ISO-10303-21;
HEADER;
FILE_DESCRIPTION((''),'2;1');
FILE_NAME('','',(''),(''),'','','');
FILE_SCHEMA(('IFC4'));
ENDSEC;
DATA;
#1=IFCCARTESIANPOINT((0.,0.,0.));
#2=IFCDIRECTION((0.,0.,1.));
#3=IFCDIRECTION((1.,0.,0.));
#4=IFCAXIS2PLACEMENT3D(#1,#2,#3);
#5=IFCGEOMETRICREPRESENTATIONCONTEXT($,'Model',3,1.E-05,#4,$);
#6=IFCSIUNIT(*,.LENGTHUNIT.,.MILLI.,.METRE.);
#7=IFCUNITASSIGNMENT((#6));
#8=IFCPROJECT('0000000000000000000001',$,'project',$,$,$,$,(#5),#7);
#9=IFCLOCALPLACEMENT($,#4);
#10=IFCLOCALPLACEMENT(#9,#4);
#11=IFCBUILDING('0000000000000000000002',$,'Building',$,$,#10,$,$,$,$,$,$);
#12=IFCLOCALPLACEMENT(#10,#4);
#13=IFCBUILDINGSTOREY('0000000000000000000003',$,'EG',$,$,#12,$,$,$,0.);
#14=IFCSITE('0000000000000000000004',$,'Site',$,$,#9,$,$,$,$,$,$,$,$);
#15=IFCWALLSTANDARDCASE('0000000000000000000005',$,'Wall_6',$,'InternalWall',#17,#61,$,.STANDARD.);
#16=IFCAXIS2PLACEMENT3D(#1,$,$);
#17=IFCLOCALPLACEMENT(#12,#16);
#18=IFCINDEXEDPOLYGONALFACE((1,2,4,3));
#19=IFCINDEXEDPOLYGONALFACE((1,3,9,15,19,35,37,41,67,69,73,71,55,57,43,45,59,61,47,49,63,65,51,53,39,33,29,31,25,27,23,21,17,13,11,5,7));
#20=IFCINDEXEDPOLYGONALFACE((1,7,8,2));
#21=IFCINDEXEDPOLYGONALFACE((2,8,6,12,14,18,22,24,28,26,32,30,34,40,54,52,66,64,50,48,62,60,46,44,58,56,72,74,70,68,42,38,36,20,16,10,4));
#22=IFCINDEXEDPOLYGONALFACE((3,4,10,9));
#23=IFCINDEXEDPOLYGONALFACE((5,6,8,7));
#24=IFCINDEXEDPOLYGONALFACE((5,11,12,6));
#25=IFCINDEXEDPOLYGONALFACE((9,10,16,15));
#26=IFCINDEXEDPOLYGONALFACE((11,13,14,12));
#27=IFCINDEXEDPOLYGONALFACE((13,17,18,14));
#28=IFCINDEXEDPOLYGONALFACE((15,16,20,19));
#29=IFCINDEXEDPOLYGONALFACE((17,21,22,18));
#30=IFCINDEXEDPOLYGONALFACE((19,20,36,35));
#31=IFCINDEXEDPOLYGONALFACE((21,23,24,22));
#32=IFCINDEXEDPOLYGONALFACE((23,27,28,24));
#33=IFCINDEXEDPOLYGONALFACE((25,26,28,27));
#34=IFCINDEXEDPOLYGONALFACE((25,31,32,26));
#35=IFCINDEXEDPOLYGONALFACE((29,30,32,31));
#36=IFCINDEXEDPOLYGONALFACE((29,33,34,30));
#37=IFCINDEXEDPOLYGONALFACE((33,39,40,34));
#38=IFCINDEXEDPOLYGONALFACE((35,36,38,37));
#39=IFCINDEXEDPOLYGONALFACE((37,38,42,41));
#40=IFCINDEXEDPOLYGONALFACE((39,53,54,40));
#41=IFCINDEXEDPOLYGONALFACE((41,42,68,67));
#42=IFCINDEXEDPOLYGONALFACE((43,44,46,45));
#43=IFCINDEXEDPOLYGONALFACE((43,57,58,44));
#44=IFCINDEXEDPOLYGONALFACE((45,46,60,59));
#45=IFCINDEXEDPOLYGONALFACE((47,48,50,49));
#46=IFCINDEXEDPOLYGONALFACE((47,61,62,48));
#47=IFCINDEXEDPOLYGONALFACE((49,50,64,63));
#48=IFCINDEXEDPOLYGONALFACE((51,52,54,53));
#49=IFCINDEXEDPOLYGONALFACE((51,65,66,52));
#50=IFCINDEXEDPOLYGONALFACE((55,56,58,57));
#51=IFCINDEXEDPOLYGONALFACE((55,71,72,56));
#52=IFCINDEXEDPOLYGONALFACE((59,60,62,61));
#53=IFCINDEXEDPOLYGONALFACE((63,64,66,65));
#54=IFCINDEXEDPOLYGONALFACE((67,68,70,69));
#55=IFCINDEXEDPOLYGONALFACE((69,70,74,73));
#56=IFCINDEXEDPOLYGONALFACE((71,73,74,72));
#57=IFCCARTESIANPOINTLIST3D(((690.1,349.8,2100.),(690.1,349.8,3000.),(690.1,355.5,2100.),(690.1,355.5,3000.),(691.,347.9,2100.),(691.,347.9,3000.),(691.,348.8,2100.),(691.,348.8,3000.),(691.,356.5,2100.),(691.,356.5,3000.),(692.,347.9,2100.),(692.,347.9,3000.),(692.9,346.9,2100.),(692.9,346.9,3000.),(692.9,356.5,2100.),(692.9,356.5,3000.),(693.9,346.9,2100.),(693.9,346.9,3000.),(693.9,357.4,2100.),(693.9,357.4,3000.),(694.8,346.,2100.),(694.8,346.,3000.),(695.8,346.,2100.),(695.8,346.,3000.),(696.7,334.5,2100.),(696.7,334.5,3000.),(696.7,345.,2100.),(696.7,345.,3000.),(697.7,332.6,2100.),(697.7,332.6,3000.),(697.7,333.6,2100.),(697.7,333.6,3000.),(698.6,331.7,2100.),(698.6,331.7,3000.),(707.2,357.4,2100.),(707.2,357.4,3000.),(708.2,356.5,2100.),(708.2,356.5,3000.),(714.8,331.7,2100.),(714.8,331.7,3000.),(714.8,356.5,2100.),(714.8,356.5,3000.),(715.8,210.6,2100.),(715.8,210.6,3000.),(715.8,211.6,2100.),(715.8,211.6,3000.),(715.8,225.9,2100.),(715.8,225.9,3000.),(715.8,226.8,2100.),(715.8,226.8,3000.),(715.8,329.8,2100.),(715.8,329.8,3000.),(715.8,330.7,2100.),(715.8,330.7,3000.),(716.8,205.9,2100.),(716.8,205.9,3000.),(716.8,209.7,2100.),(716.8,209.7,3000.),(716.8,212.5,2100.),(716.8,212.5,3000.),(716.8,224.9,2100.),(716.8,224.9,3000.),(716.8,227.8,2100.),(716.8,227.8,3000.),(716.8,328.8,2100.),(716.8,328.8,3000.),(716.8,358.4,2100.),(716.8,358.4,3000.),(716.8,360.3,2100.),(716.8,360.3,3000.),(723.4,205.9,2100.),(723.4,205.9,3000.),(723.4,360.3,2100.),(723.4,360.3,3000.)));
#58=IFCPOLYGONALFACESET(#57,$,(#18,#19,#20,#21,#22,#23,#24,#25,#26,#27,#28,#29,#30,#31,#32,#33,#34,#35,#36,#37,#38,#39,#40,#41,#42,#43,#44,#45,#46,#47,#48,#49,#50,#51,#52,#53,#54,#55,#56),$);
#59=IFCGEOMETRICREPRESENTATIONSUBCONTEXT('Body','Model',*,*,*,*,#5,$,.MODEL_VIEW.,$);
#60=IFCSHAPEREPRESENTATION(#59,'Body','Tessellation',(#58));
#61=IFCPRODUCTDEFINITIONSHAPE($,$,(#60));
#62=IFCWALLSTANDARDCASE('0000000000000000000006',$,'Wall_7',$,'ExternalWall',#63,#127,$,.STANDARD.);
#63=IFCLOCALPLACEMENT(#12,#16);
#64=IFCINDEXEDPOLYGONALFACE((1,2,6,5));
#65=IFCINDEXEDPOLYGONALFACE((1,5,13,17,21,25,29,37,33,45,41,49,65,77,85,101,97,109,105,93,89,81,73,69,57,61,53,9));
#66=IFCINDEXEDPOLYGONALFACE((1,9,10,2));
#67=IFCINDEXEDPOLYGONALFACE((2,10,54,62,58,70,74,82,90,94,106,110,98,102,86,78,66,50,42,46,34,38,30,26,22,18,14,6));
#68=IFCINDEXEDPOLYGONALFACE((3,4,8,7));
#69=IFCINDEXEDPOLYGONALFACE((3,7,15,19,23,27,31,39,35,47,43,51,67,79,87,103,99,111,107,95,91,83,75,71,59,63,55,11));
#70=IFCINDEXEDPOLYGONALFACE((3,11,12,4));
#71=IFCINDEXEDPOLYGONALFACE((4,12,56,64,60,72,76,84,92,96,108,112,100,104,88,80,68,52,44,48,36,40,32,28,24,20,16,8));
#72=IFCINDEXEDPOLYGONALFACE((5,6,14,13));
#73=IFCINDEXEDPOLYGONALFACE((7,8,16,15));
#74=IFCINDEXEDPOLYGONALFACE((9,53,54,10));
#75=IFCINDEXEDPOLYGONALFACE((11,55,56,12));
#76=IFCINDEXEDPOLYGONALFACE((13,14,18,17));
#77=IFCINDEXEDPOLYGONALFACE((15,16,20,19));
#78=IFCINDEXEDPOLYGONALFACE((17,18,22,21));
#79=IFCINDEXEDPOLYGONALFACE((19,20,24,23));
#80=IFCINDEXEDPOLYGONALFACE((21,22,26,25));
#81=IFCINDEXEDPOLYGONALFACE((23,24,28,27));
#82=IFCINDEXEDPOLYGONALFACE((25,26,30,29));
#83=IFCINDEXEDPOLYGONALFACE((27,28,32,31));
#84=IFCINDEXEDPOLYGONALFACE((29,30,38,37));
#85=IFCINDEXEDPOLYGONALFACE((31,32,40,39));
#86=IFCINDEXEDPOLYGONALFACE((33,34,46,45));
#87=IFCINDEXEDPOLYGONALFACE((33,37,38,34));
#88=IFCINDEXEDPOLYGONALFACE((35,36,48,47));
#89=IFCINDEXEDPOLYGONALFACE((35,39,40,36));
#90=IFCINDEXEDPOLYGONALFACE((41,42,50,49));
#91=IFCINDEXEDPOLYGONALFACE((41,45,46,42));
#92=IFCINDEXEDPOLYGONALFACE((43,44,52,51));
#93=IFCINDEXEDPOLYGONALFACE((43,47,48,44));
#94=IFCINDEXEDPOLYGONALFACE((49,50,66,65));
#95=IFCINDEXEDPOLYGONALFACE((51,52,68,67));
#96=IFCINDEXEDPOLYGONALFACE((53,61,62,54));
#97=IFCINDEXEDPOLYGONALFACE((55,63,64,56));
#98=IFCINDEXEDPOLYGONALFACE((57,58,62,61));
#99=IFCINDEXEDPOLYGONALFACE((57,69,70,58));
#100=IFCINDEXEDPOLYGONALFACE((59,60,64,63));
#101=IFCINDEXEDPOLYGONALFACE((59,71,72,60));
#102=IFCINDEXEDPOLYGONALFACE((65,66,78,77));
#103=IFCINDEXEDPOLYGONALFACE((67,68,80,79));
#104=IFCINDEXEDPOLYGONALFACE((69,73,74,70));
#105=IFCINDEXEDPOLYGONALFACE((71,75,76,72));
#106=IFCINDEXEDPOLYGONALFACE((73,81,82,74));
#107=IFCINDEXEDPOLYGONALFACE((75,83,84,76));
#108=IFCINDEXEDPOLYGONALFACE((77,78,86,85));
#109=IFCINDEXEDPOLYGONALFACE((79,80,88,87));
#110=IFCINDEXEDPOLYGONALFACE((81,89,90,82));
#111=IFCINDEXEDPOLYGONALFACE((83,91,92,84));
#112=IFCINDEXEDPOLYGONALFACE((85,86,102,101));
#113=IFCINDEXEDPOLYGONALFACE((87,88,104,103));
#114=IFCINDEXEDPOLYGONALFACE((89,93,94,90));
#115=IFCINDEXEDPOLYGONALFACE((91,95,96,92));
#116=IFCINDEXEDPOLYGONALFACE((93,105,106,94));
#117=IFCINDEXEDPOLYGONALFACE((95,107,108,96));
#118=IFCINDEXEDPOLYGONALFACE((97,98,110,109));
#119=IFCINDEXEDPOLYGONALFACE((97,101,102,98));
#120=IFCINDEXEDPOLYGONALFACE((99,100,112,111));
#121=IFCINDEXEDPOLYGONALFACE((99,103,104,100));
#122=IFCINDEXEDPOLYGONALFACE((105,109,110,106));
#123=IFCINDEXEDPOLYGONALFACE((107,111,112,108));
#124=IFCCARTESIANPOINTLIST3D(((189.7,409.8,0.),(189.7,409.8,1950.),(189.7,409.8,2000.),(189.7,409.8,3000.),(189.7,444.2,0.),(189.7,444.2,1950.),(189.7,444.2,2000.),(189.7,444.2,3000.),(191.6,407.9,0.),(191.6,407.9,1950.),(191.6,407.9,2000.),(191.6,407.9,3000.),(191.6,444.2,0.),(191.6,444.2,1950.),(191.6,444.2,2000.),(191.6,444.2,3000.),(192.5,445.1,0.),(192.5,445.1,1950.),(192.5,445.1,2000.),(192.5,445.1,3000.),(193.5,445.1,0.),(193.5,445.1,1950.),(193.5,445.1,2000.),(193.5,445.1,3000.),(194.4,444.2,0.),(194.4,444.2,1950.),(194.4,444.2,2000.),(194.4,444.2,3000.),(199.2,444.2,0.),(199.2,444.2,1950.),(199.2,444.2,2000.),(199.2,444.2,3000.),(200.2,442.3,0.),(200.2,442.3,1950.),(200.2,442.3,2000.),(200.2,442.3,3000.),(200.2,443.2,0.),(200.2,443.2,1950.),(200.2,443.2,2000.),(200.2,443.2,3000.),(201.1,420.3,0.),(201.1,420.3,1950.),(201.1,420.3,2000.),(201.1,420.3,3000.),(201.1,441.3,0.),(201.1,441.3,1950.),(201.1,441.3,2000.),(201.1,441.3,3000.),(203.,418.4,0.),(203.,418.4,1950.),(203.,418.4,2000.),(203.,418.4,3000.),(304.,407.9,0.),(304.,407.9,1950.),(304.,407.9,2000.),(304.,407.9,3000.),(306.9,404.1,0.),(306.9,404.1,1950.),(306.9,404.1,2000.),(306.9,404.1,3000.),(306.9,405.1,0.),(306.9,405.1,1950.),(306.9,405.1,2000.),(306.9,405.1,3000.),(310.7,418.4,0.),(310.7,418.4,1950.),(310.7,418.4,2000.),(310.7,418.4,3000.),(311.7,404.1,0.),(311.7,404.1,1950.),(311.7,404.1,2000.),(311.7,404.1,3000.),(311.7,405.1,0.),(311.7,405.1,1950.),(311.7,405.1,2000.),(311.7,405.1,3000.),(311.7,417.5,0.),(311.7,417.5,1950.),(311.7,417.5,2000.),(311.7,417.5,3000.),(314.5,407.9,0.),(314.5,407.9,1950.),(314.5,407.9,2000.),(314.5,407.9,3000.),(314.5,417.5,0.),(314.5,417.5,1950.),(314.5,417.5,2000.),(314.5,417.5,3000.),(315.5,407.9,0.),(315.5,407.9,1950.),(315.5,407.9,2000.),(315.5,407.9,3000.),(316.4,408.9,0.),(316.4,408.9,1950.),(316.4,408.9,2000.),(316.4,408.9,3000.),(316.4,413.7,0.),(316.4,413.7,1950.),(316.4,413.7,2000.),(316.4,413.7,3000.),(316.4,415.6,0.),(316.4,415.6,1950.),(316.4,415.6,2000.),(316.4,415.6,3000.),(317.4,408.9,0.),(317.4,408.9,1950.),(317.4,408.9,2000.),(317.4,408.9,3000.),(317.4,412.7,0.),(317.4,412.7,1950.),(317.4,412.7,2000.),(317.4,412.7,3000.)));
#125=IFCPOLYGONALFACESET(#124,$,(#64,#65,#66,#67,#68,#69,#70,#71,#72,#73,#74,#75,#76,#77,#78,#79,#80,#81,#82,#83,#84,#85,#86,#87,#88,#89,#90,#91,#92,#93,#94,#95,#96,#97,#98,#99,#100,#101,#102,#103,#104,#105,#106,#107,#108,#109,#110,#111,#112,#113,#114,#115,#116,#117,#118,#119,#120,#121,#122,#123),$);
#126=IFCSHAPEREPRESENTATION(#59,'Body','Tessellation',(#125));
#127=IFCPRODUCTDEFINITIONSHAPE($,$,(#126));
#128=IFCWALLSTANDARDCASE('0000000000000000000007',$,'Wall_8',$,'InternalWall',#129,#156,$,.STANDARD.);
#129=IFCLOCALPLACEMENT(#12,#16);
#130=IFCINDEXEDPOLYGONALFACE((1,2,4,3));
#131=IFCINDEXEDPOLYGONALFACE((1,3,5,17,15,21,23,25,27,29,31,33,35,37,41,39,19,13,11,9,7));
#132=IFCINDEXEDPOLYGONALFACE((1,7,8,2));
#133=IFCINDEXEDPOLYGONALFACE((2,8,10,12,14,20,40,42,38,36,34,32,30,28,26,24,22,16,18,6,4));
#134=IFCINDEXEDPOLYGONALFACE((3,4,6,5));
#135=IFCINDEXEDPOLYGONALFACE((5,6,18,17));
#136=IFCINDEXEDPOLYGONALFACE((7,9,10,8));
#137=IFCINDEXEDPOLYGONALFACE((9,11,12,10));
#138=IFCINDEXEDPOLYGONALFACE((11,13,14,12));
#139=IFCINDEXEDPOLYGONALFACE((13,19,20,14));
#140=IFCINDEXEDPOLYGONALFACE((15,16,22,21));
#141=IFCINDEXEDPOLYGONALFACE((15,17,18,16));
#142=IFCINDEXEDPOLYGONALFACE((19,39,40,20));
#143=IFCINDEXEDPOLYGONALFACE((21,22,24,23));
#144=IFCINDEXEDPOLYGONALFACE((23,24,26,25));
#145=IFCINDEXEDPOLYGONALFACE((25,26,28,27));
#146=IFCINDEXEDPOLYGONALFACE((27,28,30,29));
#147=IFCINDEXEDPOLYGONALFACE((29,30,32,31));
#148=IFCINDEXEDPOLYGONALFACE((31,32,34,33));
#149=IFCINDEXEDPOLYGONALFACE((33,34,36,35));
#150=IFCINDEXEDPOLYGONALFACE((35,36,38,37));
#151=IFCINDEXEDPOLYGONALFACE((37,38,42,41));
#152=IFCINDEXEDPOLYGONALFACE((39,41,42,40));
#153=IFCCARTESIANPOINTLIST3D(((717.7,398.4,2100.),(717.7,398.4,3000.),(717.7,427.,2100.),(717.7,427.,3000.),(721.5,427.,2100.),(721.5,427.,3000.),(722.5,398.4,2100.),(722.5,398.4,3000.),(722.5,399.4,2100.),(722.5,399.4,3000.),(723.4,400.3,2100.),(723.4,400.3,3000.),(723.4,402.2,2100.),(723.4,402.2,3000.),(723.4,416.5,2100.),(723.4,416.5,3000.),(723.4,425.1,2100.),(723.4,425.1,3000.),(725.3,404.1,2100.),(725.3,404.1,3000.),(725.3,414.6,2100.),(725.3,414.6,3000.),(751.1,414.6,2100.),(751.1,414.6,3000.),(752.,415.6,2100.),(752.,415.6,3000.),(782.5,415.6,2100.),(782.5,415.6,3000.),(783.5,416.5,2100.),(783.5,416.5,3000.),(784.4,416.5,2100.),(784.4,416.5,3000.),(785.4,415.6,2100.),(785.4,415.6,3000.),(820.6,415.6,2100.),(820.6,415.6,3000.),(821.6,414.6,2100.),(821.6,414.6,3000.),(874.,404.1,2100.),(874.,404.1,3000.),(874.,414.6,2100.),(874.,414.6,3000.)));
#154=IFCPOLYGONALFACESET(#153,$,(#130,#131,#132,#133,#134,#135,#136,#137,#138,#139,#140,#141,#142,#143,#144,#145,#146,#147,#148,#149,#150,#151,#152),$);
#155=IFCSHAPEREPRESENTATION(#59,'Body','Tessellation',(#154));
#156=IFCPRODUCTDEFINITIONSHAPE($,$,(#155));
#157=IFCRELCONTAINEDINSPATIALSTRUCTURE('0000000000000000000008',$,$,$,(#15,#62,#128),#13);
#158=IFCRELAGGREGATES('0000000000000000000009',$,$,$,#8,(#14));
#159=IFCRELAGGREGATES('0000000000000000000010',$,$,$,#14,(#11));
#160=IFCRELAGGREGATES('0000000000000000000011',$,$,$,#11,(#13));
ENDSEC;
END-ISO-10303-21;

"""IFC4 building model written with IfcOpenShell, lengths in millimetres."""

from ifc_helpers import new_model, si_unit, frame, origin_with_axes, place, context, subcontext, project, spatial, polyline, rectangle, outline, extrude, element, save


model = new_model("IFC4")

# Units and contexts
model_context = context("Model", 3, precision=1e-05, world=origin_with_axes())
body_context = subcontext(model_context, "Body", "Model", "MODEL_VIEW")
ifc_project = project(units=[si_unit("LENGTHUNIT", "METRE", prefix="MILLI")], contexts=[model_context])

# Site, building, storey
site_placement = place(None, origin_with_axes())
site = spatial("IfcSite", under=ifc_project, at=site_placement, Name="Site")
building_placement = place(site_placement, origin_with_axes())
building = spatial("IfcBuilding", under=site, at=building_placement, Name="Building")
storey_placement = place(building_placement, origin_with_axes())
storey = spatial("IfcBuildingStorey", under=building, at=storey_placement, Name="EG", Elevation=0.0)

# Wall, opening
wall_1_placement = place(storey_placement, origin_with_axes())
wall_1 = element("IfcWallStandardCase", 1, at=wall_1_placement, inside=storey, Name="Wall_6", ObjectType="InternalWall", PredefinedType="STANDARD", context=body_context, shape_type="SweptSolid", body=[
    extrude(outline(polyline([(716.8, 205.9, 0.0), (716.8, 209.7, 0.0), (715.8, 210.6, 0.0), (715.8, 211.6, 0.0), (716.8, 212.5, 0.0), (716.8, 224.9, 0.0), (715.8, 225.9, 0.0), (715.8, 226.8, 0.0), (716.8, 227.8, 0.0), (716.8, 328.8, 0.0), (715.8, 329.8, 0.0), (715.8, 330.7, 0.0), (714.8, 331.7, 0.0), (698.6, 331.7, 0.0), (697.7, 332.6, 0.0), (697.7, 333.6, 0.0), (696.7, 334.5, 0.0), (696.7, 345.0, 0.0), (695.8, 346.0, 0.0), (694.8, 346.0, 0.0), (693.9, 346.9, 0.0), (692.9, 346.9, 0.0), (692.0, 347.9, 0.0), (691.0, 347.9, 0.0), (691.0, 348.8, 0.0), (690.1, 349.8, 0.0), (690.1, 355.5, 0.0), (691.0, 356.5, 0.0), (692.9, 356.5, 0.0), (693.9, 357.4, 0.0), (707.2, 357.4, 0.0), (708.2, 356.5, 0.0), (714.8, 356.5, 0.0), (716.8, 358.4, 0.0), (716.8, 360.3, 0.0), (723.4, 360.3, 0.0), (723.4, 205.9, 0.0), (716.8, 205.9, 0.0)])), origin_with_axes(), (0.0, 0.0, 1.0), 3000.0),
])
opening_1_placement = place(wall_1_placement, origin_with_axes())
element("IfcOpeningElement", 2, at=opening_1_placement, inside=storey, cuts=wall_1, context=body_context, shape_type="SweptSolid", body=[
    extrude(rectangle(XDim=450.0, YDim=33.4), frame((706.7, 336.5, 0.0), z_axis=(0.0, 0.0, 1.0), x_axis=(0.0, 1.0, 0.0)), (0.0, 0.0, 1.0), 2100.0),
])

# Walls, openings
wall_2_placement = place(storey_placement, origin_with_axes())
wall_2 = element("IfcWallStandardCase", 3, at=wall_2_placement, inside=storey, Name="Wall_7", ObjectType="ExternalWall", PredefinedType="STANDARD", context=body_context, shape_type="SweptSolid", body=[
    extrude(outline(polyline([(306.9, 404.1, 0.0), (306.9, 405.1, 0.0), (304.0, 407.9, 0.0), (191.6, 407.9, 0.0), (189.7, 409.8, 0.0), (189.7, 444.2, 0.0), (191.6, 444.2, 0.0), (192.5, 445.1, 0.0), (193.5, 445.1, 0.0), (194.4, 444.2, 0.0), (199.2, 444.2, 0.0), (200.2, 443.2, 0.0), (200.2, 442.3, 0.0), (201.1, 441.3, 0.0), (201.1, 420.3, 0.0), (203.0, 418.4, 0.0), (310.7, 418.4, 0.0), (311.7, 417.5, 0.0), (314.5, 417.5, 0.0), (316.4, 415.6, 0.0), (316.4, 413.7, 0.0), (317.4, 412.7, 0.0), (317.4, 408.9, 0.0), (316.4, 408.9, 0.0), (315.5, 407.9, 0.0), (314.5, 407.9, 0.0), (311.7, 405.1, 0.0), (311.7, 404.1, 0.0), (306.9, 404.1, 0.0)])), origin_with_axes(), (0.0, 0.0, 1.0), 3000.0),
])
opening_2_placement = place(wall_2_placement, origin_with_axes())
element("IfcOpeningElement", 4, at=opening_2_placement, inside=storey, cuts=wall_2, context=body_context, shape_type="SweptSolid", body=[
    extrude(rectangle(XDim=600.0, YDim=37.2), frame((194.3, 426.5, 1950.0), z_axis=(0.0, 0.0, 1.0), x_axis=(-0.999454, 0.03304, 0.0)), (0.0, 0.0, 1.0), 50.0),
])
opening_3_placement = place(wall_2_placement, origin_with_axes())
element("IfcOpeningElement", 5, at=opening_3_placement, inside=storey, cuts=wall_2, context=body_context, shape_type="SweptSolid", body=[
    extrude(rectangle(XDim=600.0, YDim=37.2), frame((189.2, 426.6, 1950.0), z_axis=(0.0, 0.0, 1.0), x_axis=(-0.999454, 0.03304, 0.0)), (0.0, 0.0, 1.0), 50.0),
])
wall_3_placement = place(storey_placement, origin_with_axes())
wall_3 = element("IfcWallStandardCase", 6, at=wall_3_placement, inside=storey, Name="Wall_8", ObjectType="InternalWall", PredefinedType="STANDARD", context=body_context, shape_type="SweptSolid", body=[
    extrude(outline(polyline([(717.7, 398.4, 0.0), (717.7, 427.0, 0.0), (721.5, 427.0, 0.0), (723.4, 425.1, 0.0), (723.4, 416.5, 0.0), (725.3, 414.6, 0.0), (751.1, 414.6, 0.0), (752.0, 415.6, 0.0), (782.5, 415.6, 0.0), (783.5, 416.5, 0.0), (784.4, 416.5, 0.0), (785.4, 415.6, 0.0), (820.6, 415.6, 0.0), (821.6, 414.6, 0.0), (874.0, 414.6, 0.0), (874.0, 404.1, 0.0), (725.3, 404.1, 0.0), (723.4, 402.2, 0.0), (723.4, 400.3, 0.0), (722.5, 399.4, 0.0), (722.5, 398.4, 0.0), (717.7, 398.4, 0.0)])), origin_with_axes(), (0.0, 0.0, 1.0), 3000.0),
])
opening_4_placement = place(wall_3_placement, origin_with_axes())
element("IfcOpeningElement", 7, at=opening_4_placement, inside=storey, cuts=wall_3, context=body_context, shape_type="SweptSolid", body=[
    extrude(rectangle(XDim=450.0, YDim=28.6), frame((738.2, 412.7, 0.0), z_axis=(0.0, 0.0, 1.0), x_axis=(1.0, 0.0, 0.0)), (0.0, 0.0, 1.0), 2100.0),
])
opening_5_placement = place(wall_3_placement, origin_with_axes())
element("IfcOpeningElement", 8, at=opening_5_placement, inside=storey, cuts=wall_3, context=body_context, shape_type="SweptSolid", body=[
    extrude(rectangle(XDim=450.0, YDim=28.6), frame((733.9, 412.7, 0.0), z_axis=(0.0, 0.0, 1.0), x_axis=(1.0, 0.0, 0.0)), (0.0, 0.0, 1.0), 2100.0),
])

save(model, "model.ifc")
